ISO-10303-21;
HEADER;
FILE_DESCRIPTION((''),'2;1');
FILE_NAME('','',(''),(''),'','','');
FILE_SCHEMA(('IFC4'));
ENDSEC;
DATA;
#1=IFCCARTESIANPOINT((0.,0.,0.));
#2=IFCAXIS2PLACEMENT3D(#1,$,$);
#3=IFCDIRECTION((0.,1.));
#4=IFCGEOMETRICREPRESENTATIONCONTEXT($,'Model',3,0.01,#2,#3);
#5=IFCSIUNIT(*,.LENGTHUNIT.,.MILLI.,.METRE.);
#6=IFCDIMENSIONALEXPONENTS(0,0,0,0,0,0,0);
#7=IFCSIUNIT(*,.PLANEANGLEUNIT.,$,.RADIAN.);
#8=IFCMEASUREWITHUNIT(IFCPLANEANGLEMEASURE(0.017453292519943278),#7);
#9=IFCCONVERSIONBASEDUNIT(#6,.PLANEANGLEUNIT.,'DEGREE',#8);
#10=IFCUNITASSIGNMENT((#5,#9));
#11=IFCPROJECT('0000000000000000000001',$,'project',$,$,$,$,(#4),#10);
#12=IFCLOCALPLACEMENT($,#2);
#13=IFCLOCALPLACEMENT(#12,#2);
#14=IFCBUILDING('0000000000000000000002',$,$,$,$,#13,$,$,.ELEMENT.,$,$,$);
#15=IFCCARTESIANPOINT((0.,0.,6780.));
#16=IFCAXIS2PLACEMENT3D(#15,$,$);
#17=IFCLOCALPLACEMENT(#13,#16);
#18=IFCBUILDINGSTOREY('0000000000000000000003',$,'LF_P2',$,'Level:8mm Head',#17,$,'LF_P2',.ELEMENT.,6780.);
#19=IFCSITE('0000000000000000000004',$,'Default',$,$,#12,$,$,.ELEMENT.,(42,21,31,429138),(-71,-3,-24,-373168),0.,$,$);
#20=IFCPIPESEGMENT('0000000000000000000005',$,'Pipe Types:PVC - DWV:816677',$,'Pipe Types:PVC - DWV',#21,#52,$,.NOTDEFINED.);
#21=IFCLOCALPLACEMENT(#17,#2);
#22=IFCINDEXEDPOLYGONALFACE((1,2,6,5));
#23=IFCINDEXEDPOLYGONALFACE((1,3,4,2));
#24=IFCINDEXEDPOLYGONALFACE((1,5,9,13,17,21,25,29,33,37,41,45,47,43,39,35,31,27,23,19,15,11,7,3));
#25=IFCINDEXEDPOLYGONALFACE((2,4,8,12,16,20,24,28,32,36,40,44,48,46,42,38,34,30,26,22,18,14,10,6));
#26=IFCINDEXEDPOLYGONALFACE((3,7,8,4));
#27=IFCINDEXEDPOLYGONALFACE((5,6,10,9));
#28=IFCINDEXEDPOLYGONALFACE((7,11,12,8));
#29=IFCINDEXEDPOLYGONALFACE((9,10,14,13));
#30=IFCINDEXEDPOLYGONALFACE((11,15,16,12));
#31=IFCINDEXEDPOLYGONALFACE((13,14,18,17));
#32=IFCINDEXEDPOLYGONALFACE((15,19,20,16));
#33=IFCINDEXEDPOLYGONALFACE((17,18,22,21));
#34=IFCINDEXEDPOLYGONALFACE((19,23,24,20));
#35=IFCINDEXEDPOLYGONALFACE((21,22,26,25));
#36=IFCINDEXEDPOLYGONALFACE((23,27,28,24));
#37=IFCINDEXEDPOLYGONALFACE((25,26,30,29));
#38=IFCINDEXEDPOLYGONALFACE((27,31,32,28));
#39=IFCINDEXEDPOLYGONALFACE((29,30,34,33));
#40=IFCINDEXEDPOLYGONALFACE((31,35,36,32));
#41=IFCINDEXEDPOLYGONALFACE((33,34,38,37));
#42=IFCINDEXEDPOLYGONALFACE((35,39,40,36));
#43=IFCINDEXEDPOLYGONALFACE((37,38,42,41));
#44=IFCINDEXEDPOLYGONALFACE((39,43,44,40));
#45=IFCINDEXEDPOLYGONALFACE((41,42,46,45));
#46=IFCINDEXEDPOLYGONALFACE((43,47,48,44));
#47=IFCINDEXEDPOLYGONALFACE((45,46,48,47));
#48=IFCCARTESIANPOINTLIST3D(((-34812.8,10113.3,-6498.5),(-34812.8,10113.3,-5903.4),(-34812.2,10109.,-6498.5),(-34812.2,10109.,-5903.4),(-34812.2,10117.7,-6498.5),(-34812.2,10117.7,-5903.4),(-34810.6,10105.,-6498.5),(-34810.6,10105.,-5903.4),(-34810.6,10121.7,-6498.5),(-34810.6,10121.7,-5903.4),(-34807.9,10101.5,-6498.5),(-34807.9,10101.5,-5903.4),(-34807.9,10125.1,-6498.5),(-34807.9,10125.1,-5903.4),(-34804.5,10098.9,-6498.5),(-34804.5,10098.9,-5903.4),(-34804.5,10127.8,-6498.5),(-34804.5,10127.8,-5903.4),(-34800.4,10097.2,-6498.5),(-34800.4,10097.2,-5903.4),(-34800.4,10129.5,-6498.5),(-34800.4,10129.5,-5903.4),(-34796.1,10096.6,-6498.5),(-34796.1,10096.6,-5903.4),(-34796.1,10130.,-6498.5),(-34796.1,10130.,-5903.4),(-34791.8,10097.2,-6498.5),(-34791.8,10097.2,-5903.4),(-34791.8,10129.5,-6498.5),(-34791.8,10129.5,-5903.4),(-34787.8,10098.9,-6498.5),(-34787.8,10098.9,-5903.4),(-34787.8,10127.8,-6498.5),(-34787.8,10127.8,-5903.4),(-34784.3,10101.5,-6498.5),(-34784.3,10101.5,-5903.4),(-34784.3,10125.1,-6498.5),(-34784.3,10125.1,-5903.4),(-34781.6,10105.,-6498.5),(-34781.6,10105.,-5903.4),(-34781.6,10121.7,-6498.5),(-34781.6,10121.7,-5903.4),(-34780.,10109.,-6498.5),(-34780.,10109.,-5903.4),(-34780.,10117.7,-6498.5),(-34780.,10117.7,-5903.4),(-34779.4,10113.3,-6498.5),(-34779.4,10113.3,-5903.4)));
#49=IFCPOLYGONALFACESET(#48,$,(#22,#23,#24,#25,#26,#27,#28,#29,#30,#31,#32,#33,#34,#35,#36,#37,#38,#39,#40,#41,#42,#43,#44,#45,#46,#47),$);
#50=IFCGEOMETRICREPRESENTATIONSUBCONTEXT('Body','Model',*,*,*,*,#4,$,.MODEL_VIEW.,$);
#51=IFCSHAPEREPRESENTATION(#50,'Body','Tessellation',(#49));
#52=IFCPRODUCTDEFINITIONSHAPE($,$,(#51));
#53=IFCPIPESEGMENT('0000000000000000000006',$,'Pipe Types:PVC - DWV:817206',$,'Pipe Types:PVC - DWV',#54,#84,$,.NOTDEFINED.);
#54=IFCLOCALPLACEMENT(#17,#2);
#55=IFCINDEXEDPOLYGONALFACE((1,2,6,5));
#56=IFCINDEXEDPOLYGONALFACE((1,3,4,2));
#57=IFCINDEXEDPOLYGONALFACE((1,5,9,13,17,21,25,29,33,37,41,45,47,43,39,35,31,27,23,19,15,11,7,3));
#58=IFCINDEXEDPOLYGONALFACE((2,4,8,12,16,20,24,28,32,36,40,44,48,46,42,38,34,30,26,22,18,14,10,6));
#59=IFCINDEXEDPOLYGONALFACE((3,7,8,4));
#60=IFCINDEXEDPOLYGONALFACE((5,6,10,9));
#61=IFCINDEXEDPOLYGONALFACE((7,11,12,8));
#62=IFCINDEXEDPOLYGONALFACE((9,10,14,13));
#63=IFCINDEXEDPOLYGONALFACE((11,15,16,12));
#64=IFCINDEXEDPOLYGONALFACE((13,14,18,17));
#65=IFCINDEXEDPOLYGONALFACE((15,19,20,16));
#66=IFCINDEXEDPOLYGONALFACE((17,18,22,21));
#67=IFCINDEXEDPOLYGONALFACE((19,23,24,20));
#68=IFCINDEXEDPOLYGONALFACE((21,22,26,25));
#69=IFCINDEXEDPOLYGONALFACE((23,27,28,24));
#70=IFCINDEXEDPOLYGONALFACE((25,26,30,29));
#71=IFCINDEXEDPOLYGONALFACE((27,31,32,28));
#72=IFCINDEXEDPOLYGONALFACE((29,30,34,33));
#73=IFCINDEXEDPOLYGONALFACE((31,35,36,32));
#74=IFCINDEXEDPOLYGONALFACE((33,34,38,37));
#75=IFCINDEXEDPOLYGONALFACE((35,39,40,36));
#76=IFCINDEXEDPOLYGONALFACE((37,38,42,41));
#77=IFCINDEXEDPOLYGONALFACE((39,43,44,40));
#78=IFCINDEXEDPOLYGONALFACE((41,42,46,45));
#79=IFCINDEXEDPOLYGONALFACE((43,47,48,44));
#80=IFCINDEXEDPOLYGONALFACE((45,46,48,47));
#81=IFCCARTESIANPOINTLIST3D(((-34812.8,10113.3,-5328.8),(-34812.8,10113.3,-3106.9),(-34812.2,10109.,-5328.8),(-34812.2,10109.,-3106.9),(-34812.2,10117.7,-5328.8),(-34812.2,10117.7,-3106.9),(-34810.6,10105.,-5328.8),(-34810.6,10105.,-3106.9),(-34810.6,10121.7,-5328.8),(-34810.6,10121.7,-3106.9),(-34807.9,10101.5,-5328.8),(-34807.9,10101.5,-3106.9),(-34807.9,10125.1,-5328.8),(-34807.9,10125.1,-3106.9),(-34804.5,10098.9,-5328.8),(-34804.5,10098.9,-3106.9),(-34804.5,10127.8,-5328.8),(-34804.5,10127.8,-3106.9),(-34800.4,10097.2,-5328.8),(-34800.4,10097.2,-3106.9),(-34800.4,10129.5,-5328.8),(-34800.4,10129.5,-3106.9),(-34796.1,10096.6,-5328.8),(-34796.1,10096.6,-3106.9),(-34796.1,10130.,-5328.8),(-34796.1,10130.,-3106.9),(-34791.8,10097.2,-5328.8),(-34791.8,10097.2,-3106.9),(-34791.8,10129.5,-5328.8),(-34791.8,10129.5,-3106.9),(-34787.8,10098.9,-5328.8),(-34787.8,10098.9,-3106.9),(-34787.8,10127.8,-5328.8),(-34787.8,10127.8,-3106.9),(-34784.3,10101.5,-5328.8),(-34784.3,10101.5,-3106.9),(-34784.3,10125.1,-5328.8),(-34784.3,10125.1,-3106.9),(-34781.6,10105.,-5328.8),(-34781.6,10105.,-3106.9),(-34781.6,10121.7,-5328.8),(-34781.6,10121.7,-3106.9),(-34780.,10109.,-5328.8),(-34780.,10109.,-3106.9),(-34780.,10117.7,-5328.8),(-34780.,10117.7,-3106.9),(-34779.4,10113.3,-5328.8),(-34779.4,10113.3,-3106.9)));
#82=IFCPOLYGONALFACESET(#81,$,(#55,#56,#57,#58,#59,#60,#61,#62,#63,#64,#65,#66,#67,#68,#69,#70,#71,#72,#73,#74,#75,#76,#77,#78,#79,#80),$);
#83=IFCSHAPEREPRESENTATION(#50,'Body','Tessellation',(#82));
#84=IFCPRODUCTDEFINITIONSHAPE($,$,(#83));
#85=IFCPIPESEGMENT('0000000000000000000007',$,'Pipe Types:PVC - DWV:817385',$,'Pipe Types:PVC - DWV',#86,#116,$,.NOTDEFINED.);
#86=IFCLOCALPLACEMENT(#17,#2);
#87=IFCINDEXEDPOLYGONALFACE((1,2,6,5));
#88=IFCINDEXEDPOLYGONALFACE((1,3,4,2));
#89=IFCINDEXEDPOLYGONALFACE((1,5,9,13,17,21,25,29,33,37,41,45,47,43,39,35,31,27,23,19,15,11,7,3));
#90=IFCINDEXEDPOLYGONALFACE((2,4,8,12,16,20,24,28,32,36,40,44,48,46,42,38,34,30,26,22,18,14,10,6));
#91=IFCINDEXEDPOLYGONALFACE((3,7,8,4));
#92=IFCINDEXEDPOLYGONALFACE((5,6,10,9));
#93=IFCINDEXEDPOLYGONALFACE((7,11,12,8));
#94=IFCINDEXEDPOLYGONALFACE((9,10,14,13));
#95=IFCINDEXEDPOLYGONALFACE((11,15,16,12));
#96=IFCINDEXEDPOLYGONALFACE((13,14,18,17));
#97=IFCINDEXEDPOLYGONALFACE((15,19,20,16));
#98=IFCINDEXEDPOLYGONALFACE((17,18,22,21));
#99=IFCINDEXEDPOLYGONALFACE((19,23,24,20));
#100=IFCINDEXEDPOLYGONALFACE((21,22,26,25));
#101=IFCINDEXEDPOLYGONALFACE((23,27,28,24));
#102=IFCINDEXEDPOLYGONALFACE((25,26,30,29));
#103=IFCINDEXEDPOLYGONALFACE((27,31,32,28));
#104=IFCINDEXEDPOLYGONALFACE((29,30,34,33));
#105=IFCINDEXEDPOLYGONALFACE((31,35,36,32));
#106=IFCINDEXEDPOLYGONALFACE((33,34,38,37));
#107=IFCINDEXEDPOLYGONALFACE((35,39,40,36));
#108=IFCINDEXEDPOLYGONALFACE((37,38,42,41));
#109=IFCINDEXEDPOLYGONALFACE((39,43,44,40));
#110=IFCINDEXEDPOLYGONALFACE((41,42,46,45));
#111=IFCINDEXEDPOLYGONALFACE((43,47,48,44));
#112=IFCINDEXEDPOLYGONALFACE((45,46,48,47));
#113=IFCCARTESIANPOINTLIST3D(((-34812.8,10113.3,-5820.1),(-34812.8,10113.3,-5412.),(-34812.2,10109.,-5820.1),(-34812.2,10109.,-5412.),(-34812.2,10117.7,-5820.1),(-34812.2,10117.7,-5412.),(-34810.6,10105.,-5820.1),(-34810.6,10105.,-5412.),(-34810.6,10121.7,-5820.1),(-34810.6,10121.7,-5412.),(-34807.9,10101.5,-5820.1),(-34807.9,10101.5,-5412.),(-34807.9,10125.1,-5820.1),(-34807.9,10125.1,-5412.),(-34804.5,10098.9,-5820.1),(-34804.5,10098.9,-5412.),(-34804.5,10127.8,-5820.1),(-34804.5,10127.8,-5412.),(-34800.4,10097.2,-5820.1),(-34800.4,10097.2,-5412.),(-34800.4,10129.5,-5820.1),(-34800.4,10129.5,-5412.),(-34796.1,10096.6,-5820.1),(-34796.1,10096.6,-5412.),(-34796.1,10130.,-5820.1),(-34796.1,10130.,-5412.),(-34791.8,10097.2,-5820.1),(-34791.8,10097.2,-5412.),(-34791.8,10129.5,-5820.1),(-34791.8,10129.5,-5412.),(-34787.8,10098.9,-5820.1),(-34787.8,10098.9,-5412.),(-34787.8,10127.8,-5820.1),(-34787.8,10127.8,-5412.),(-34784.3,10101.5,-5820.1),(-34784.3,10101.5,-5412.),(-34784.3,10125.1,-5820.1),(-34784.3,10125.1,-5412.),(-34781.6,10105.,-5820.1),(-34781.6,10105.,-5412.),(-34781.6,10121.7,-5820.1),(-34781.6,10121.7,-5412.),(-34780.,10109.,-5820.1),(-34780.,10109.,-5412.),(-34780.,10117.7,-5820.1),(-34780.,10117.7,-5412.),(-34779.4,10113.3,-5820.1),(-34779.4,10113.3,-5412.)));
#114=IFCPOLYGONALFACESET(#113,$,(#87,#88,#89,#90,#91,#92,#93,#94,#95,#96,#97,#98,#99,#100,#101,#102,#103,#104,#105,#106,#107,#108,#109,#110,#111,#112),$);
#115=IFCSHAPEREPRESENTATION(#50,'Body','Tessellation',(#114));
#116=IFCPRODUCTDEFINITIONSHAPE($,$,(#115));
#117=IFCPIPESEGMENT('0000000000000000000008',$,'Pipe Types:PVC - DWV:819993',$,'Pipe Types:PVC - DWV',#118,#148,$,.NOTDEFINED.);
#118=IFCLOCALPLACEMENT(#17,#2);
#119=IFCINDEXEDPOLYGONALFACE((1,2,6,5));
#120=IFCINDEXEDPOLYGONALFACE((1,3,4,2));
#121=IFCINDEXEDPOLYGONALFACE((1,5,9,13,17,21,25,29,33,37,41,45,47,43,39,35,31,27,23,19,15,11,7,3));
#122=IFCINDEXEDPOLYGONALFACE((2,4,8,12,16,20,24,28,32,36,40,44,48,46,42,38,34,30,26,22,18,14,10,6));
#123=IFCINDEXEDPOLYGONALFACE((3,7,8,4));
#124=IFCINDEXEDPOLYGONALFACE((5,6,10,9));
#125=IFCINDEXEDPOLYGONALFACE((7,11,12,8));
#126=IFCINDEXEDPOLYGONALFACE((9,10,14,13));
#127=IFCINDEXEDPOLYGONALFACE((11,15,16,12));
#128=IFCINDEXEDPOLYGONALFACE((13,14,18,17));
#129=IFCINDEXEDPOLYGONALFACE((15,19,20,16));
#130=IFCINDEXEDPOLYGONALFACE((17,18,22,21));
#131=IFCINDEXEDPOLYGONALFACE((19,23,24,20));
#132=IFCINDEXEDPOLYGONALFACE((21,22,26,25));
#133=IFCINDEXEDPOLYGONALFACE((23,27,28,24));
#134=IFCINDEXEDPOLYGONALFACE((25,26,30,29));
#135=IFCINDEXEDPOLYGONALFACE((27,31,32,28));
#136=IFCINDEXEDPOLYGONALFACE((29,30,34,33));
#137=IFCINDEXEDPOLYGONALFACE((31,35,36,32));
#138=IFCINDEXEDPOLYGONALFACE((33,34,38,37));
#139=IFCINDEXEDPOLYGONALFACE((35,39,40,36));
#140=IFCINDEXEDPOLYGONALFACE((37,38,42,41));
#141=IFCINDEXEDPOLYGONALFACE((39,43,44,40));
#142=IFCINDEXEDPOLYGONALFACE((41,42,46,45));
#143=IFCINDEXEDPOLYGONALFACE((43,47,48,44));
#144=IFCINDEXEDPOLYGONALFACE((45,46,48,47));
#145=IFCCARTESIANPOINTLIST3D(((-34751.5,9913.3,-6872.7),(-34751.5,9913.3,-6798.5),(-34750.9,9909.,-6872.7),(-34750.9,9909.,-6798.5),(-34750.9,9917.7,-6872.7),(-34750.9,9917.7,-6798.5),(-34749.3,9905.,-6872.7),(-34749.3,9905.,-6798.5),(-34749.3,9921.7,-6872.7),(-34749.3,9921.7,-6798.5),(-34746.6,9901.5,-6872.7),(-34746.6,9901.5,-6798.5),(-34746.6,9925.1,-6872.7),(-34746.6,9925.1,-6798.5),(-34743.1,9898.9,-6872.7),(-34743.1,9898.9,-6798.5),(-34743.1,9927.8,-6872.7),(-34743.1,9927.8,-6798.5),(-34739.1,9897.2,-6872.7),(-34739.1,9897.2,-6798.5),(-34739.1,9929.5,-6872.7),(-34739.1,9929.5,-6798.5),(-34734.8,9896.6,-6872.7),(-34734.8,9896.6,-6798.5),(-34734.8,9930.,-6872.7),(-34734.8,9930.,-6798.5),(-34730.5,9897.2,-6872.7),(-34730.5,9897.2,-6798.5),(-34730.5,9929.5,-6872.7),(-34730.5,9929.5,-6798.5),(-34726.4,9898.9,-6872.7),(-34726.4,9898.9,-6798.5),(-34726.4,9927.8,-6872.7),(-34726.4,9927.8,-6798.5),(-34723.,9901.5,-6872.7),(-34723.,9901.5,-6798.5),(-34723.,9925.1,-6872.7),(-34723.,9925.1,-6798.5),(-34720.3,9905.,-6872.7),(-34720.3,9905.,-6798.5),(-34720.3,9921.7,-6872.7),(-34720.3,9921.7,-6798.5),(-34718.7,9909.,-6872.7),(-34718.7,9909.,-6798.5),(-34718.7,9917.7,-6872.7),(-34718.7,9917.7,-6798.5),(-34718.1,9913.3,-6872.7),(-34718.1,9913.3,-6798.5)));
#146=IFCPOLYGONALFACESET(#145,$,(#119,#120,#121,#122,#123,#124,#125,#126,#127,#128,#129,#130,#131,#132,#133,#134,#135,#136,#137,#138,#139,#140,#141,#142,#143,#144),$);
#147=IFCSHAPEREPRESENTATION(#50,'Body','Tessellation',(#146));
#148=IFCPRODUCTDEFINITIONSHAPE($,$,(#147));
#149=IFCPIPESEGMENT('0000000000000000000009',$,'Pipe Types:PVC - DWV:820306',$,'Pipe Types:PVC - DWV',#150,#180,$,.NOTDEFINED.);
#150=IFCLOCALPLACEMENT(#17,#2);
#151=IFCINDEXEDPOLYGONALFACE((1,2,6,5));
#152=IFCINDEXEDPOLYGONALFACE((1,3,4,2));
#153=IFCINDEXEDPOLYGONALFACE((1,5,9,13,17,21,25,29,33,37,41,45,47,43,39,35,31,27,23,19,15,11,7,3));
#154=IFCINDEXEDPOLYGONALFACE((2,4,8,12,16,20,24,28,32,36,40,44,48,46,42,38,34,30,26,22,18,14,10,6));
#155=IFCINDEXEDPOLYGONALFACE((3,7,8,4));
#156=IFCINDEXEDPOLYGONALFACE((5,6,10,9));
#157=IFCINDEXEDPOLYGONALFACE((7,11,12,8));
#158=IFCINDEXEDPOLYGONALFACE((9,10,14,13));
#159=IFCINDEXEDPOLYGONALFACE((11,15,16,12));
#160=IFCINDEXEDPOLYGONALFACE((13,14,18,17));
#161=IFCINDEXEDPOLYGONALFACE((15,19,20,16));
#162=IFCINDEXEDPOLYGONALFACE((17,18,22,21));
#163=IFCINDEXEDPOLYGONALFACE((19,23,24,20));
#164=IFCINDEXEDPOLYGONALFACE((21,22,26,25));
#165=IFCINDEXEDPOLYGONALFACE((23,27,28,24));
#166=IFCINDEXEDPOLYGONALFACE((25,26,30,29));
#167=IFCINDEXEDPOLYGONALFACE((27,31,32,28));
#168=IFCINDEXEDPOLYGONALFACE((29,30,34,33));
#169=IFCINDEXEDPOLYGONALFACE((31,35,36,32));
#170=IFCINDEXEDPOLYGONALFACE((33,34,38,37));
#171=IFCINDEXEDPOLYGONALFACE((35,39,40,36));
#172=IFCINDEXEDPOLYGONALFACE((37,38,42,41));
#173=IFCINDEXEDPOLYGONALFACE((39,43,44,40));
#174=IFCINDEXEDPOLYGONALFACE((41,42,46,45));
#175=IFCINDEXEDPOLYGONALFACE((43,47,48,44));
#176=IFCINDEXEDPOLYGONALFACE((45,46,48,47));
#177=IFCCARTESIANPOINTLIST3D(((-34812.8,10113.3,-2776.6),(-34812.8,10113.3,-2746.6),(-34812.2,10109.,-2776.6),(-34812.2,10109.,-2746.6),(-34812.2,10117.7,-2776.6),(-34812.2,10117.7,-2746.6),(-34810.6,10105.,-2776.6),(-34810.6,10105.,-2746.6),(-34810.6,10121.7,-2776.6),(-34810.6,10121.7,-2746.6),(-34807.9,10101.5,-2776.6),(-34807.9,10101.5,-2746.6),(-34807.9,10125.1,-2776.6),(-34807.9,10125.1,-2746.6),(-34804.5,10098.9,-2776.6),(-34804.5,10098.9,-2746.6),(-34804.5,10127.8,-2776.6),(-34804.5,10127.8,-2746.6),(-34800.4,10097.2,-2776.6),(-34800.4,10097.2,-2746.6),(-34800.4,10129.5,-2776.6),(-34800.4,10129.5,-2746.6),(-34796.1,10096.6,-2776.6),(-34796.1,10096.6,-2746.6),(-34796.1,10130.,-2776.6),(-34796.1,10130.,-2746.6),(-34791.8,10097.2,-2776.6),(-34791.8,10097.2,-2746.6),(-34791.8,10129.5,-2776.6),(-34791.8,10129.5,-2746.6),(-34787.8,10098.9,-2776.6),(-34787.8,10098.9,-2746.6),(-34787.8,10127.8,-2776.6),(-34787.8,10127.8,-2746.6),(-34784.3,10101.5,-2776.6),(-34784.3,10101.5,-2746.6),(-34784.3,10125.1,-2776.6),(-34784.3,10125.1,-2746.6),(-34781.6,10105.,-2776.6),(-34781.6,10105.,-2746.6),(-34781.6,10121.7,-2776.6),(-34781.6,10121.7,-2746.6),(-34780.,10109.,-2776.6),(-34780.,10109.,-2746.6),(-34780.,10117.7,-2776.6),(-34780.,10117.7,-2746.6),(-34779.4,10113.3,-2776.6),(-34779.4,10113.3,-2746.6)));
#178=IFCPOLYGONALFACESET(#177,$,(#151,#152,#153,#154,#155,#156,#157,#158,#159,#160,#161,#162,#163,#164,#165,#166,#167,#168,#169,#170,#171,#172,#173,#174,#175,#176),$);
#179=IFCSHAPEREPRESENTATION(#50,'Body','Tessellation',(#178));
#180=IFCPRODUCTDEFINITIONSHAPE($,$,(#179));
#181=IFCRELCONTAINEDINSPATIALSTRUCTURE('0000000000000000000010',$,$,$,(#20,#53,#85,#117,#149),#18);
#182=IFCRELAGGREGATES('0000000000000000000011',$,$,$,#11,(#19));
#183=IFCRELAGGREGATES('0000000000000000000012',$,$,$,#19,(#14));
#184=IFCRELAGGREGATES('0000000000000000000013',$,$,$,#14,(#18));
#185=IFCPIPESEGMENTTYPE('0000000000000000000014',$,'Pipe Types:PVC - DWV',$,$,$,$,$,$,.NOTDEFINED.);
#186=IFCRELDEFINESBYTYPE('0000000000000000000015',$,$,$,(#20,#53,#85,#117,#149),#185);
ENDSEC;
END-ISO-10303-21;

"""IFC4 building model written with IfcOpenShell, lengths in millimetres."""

from ifc_helpers import new_model, entity, si_unit, converted_unit, direction, frame, origin, place, context, subcontext, project, spatial, arc, indexed_curve, outline, extrude, type_object, element, save


model = new_model("IFC4")

# Units and contexts
model_context = context("Model", 3, precision=0.01, world=origin(), true_north=direction((0.0, 1.0)))
body_context = subcontext(model_context, "Body", "Model", "MODEL_VIEW")
ifc_project = project(units=[si_unit("LENGTHUNIT", "METRE", prefix="MILLI"), converted_unit("PLANEANGLEUNIT", "DEGREE", entity("IfcPlaneAngleMeasure", 0.017453292519943278), si_unit("PLANEANGLEUNIT", "RADIAN"), dimensions=[0, 0, 0, 0, 0, 0, 0])], contexts=[model_context])

# Site, building, storey
site_placement = place(None, origin())
site = spatial("IfcSite", under=ifc_project, at=site_placement, Name="Default", CompositionType="ELEMENT", RefLatitude=(42, 21, 31, 429138), RefLongitude=(-71, -3, -24, -373168), RefElevation=0.0)
building_placement = place(site_placement, origin())
building = spatial("IfcBuilding", under=site, at=building_placement, CompositionType="ELEMENT")
storey_placement = place(building_placement, frame((0.0, 0.0, 6780.0)))
storey = spatial("IfcBuildingStorey", under=building, at=storey_placement, Name="LF_P2", ObjectType="Level:8mm Head", LongName="LF_P2", CompositionType="ELEMENT", Elevation=6780.0)

# Pipe segments
pipe_segment_type_1 = type_object("IfcPipeSegmentType", Name="Pipe Types:PVC - DWV", PredefinedType="NOTDEFINED")
pipe_segment_1_placement = place(storey_placement, origin())
element("IfcPipeSegment", 1, at=pipe_segment_1_placement, inside=storey, type_object=pipe_segment_type_1, Name="Pipe Types:PVC - DWV:816677", ObjectType="Pipe Types:PVC - DWV", PredefinedType="NOTDEFINED", context=body_context, shape_type="SweptSolid", body=[
    extrude(outline(indexed_curve([(16.7, 0.0), (11.8, 11.8), (0.0, 16.7), (-11.8, 11.8), (-16.7, 0.0), (-11.8, -11.8), (0.0, -16.7), (11.8, -11.8)], segments=[arc(1, 2, 3), arc(3, 4, 5), arc(5, 6, 7), arc(7, 8, 1)], self_intersect=False)), frame((-34796.1, 10113.3, -6498.5)), (0.0, 0.0, 1.0), 595.1),
])
pipe_segment_2_placement = place(storey_placement, origin())
element("IfcPipeSegment", 2, at=pipe_segment_2_placement, inside=storey, type_object=pipe_segment_type_1, Name="Pipe Types:PVC - DWV:817206", ObjectType="Pipe Types:PVC - DWV", PredefinedType="NOTDEFINED", context=body_context, shape_type="SweptSolid", body=[
    extrude(outline(indexed_curve([(16.7, 0.0), (11.8, 11.8), (0.0, 16.7), (-11.8, 11.8), (-16.7, 0.0), (-11.8, -11.8), (0.0, -16.7), (11.8, -11.8)], segments=[arc(1, 2, 3), arc(3, 4, 5), arc(5, 6, 7), arc(7, 8, 1)], self_intersect=False)), frame((-34796.1, 10113.3, -5328.8)), (0.0, 0.0, 1.0), 2221.9),
])
pipe_segment_3_placement = place(storey_placement, origin())
element("IfcPipeSegment", 3, at=pipe_segment_3_placement, inside=storey, type_object=pipe_segment_type_1, Name="Pipe Types:PVC - DWV:817385", ObjectType="Pipe Types:PVC - DWV", PredefinedType="NOTDEFINED", context=body_context, shape_type="SweptSolid", body=[
    extrude(outline(indexed_curve([(16.7, 0.0), (11.8, 11.8), (0.0, 16.7), (-11.8, 11.8), (-16.7, 0.0), (-11.8, -11.8), (0.0, -16.7), (11.8, -11.8)], segments=[arc(1, 2, 3), arc(3, 4, 5), arc(5, 6, 7), arc(7, 8, 1)], self_intersect=False)), frame((-34796.1, 10113.3, -5820.1)), (0.0, 0.0, 1.0), 408.1),
])
pipe_segment_4_placement = place(storey_placement, origin())
element("IfcPipeSegment", 4, at=pipe_segment_4_placement, inside=storey, type_object=pipe_segment_type_1, Name="Pipe Types:PVC - DWV:819993", ObjectType="Pipe Types:PVC - DWV", PredefinedType="NOTDEFINED", context=body_context, shape_type="SweptSolid", body=[
    extrude(outline(indexed_curve([(16.7, 0.0), (11.8, 11.8), (0.0, 16.7), (-11.8, 11.8), (-16.7, 0.0), (-11.8, -11.8), (0.0, -16.7), (11.8, -11.8)], segments=[arc(1, 2, 3), arc(3, 4, 5), arc(5, 6, 7), arc(7, 8, 1)], self_intersect=False)), frame((-34734.8, 9913.3, -6872.7)), (0.0, 0.0, 1.0), 74.2),
])
pipe_segment_5_placement = place(storey_placement, origin())
element("IfcPipeSegment", 5, at=pipe_segment_5_placement, inside=storey, type_object=pipe_segment_type_1, Name="Pipe Types:PVC - DWV:820306", ObjectType="Pipe Types:PVC - DWV", PredefinedType="NOTDEFINED", context=body_context, shape_type="SweptSolid", body=[
    extrude(outline(indexed_curve([(16.7, 0.0), (11.8, 11.8), (0.0, 16.7), (-11.8, 11.8), (-16.7, 0.0), (-11.8, -11.8), (0.0, -16.7), (11.8, -11.8)], segments=[arc(1, 2, 3), arc(3, 4, 5), arc(5, 6, 7), arc(7, 8, 1)], self_intersect=False)), frame((-34796.1, 10113.3, -2776.6)), (0.0, 0.0, 1.0), 30.0),
])

save(model, "model.ifc")
